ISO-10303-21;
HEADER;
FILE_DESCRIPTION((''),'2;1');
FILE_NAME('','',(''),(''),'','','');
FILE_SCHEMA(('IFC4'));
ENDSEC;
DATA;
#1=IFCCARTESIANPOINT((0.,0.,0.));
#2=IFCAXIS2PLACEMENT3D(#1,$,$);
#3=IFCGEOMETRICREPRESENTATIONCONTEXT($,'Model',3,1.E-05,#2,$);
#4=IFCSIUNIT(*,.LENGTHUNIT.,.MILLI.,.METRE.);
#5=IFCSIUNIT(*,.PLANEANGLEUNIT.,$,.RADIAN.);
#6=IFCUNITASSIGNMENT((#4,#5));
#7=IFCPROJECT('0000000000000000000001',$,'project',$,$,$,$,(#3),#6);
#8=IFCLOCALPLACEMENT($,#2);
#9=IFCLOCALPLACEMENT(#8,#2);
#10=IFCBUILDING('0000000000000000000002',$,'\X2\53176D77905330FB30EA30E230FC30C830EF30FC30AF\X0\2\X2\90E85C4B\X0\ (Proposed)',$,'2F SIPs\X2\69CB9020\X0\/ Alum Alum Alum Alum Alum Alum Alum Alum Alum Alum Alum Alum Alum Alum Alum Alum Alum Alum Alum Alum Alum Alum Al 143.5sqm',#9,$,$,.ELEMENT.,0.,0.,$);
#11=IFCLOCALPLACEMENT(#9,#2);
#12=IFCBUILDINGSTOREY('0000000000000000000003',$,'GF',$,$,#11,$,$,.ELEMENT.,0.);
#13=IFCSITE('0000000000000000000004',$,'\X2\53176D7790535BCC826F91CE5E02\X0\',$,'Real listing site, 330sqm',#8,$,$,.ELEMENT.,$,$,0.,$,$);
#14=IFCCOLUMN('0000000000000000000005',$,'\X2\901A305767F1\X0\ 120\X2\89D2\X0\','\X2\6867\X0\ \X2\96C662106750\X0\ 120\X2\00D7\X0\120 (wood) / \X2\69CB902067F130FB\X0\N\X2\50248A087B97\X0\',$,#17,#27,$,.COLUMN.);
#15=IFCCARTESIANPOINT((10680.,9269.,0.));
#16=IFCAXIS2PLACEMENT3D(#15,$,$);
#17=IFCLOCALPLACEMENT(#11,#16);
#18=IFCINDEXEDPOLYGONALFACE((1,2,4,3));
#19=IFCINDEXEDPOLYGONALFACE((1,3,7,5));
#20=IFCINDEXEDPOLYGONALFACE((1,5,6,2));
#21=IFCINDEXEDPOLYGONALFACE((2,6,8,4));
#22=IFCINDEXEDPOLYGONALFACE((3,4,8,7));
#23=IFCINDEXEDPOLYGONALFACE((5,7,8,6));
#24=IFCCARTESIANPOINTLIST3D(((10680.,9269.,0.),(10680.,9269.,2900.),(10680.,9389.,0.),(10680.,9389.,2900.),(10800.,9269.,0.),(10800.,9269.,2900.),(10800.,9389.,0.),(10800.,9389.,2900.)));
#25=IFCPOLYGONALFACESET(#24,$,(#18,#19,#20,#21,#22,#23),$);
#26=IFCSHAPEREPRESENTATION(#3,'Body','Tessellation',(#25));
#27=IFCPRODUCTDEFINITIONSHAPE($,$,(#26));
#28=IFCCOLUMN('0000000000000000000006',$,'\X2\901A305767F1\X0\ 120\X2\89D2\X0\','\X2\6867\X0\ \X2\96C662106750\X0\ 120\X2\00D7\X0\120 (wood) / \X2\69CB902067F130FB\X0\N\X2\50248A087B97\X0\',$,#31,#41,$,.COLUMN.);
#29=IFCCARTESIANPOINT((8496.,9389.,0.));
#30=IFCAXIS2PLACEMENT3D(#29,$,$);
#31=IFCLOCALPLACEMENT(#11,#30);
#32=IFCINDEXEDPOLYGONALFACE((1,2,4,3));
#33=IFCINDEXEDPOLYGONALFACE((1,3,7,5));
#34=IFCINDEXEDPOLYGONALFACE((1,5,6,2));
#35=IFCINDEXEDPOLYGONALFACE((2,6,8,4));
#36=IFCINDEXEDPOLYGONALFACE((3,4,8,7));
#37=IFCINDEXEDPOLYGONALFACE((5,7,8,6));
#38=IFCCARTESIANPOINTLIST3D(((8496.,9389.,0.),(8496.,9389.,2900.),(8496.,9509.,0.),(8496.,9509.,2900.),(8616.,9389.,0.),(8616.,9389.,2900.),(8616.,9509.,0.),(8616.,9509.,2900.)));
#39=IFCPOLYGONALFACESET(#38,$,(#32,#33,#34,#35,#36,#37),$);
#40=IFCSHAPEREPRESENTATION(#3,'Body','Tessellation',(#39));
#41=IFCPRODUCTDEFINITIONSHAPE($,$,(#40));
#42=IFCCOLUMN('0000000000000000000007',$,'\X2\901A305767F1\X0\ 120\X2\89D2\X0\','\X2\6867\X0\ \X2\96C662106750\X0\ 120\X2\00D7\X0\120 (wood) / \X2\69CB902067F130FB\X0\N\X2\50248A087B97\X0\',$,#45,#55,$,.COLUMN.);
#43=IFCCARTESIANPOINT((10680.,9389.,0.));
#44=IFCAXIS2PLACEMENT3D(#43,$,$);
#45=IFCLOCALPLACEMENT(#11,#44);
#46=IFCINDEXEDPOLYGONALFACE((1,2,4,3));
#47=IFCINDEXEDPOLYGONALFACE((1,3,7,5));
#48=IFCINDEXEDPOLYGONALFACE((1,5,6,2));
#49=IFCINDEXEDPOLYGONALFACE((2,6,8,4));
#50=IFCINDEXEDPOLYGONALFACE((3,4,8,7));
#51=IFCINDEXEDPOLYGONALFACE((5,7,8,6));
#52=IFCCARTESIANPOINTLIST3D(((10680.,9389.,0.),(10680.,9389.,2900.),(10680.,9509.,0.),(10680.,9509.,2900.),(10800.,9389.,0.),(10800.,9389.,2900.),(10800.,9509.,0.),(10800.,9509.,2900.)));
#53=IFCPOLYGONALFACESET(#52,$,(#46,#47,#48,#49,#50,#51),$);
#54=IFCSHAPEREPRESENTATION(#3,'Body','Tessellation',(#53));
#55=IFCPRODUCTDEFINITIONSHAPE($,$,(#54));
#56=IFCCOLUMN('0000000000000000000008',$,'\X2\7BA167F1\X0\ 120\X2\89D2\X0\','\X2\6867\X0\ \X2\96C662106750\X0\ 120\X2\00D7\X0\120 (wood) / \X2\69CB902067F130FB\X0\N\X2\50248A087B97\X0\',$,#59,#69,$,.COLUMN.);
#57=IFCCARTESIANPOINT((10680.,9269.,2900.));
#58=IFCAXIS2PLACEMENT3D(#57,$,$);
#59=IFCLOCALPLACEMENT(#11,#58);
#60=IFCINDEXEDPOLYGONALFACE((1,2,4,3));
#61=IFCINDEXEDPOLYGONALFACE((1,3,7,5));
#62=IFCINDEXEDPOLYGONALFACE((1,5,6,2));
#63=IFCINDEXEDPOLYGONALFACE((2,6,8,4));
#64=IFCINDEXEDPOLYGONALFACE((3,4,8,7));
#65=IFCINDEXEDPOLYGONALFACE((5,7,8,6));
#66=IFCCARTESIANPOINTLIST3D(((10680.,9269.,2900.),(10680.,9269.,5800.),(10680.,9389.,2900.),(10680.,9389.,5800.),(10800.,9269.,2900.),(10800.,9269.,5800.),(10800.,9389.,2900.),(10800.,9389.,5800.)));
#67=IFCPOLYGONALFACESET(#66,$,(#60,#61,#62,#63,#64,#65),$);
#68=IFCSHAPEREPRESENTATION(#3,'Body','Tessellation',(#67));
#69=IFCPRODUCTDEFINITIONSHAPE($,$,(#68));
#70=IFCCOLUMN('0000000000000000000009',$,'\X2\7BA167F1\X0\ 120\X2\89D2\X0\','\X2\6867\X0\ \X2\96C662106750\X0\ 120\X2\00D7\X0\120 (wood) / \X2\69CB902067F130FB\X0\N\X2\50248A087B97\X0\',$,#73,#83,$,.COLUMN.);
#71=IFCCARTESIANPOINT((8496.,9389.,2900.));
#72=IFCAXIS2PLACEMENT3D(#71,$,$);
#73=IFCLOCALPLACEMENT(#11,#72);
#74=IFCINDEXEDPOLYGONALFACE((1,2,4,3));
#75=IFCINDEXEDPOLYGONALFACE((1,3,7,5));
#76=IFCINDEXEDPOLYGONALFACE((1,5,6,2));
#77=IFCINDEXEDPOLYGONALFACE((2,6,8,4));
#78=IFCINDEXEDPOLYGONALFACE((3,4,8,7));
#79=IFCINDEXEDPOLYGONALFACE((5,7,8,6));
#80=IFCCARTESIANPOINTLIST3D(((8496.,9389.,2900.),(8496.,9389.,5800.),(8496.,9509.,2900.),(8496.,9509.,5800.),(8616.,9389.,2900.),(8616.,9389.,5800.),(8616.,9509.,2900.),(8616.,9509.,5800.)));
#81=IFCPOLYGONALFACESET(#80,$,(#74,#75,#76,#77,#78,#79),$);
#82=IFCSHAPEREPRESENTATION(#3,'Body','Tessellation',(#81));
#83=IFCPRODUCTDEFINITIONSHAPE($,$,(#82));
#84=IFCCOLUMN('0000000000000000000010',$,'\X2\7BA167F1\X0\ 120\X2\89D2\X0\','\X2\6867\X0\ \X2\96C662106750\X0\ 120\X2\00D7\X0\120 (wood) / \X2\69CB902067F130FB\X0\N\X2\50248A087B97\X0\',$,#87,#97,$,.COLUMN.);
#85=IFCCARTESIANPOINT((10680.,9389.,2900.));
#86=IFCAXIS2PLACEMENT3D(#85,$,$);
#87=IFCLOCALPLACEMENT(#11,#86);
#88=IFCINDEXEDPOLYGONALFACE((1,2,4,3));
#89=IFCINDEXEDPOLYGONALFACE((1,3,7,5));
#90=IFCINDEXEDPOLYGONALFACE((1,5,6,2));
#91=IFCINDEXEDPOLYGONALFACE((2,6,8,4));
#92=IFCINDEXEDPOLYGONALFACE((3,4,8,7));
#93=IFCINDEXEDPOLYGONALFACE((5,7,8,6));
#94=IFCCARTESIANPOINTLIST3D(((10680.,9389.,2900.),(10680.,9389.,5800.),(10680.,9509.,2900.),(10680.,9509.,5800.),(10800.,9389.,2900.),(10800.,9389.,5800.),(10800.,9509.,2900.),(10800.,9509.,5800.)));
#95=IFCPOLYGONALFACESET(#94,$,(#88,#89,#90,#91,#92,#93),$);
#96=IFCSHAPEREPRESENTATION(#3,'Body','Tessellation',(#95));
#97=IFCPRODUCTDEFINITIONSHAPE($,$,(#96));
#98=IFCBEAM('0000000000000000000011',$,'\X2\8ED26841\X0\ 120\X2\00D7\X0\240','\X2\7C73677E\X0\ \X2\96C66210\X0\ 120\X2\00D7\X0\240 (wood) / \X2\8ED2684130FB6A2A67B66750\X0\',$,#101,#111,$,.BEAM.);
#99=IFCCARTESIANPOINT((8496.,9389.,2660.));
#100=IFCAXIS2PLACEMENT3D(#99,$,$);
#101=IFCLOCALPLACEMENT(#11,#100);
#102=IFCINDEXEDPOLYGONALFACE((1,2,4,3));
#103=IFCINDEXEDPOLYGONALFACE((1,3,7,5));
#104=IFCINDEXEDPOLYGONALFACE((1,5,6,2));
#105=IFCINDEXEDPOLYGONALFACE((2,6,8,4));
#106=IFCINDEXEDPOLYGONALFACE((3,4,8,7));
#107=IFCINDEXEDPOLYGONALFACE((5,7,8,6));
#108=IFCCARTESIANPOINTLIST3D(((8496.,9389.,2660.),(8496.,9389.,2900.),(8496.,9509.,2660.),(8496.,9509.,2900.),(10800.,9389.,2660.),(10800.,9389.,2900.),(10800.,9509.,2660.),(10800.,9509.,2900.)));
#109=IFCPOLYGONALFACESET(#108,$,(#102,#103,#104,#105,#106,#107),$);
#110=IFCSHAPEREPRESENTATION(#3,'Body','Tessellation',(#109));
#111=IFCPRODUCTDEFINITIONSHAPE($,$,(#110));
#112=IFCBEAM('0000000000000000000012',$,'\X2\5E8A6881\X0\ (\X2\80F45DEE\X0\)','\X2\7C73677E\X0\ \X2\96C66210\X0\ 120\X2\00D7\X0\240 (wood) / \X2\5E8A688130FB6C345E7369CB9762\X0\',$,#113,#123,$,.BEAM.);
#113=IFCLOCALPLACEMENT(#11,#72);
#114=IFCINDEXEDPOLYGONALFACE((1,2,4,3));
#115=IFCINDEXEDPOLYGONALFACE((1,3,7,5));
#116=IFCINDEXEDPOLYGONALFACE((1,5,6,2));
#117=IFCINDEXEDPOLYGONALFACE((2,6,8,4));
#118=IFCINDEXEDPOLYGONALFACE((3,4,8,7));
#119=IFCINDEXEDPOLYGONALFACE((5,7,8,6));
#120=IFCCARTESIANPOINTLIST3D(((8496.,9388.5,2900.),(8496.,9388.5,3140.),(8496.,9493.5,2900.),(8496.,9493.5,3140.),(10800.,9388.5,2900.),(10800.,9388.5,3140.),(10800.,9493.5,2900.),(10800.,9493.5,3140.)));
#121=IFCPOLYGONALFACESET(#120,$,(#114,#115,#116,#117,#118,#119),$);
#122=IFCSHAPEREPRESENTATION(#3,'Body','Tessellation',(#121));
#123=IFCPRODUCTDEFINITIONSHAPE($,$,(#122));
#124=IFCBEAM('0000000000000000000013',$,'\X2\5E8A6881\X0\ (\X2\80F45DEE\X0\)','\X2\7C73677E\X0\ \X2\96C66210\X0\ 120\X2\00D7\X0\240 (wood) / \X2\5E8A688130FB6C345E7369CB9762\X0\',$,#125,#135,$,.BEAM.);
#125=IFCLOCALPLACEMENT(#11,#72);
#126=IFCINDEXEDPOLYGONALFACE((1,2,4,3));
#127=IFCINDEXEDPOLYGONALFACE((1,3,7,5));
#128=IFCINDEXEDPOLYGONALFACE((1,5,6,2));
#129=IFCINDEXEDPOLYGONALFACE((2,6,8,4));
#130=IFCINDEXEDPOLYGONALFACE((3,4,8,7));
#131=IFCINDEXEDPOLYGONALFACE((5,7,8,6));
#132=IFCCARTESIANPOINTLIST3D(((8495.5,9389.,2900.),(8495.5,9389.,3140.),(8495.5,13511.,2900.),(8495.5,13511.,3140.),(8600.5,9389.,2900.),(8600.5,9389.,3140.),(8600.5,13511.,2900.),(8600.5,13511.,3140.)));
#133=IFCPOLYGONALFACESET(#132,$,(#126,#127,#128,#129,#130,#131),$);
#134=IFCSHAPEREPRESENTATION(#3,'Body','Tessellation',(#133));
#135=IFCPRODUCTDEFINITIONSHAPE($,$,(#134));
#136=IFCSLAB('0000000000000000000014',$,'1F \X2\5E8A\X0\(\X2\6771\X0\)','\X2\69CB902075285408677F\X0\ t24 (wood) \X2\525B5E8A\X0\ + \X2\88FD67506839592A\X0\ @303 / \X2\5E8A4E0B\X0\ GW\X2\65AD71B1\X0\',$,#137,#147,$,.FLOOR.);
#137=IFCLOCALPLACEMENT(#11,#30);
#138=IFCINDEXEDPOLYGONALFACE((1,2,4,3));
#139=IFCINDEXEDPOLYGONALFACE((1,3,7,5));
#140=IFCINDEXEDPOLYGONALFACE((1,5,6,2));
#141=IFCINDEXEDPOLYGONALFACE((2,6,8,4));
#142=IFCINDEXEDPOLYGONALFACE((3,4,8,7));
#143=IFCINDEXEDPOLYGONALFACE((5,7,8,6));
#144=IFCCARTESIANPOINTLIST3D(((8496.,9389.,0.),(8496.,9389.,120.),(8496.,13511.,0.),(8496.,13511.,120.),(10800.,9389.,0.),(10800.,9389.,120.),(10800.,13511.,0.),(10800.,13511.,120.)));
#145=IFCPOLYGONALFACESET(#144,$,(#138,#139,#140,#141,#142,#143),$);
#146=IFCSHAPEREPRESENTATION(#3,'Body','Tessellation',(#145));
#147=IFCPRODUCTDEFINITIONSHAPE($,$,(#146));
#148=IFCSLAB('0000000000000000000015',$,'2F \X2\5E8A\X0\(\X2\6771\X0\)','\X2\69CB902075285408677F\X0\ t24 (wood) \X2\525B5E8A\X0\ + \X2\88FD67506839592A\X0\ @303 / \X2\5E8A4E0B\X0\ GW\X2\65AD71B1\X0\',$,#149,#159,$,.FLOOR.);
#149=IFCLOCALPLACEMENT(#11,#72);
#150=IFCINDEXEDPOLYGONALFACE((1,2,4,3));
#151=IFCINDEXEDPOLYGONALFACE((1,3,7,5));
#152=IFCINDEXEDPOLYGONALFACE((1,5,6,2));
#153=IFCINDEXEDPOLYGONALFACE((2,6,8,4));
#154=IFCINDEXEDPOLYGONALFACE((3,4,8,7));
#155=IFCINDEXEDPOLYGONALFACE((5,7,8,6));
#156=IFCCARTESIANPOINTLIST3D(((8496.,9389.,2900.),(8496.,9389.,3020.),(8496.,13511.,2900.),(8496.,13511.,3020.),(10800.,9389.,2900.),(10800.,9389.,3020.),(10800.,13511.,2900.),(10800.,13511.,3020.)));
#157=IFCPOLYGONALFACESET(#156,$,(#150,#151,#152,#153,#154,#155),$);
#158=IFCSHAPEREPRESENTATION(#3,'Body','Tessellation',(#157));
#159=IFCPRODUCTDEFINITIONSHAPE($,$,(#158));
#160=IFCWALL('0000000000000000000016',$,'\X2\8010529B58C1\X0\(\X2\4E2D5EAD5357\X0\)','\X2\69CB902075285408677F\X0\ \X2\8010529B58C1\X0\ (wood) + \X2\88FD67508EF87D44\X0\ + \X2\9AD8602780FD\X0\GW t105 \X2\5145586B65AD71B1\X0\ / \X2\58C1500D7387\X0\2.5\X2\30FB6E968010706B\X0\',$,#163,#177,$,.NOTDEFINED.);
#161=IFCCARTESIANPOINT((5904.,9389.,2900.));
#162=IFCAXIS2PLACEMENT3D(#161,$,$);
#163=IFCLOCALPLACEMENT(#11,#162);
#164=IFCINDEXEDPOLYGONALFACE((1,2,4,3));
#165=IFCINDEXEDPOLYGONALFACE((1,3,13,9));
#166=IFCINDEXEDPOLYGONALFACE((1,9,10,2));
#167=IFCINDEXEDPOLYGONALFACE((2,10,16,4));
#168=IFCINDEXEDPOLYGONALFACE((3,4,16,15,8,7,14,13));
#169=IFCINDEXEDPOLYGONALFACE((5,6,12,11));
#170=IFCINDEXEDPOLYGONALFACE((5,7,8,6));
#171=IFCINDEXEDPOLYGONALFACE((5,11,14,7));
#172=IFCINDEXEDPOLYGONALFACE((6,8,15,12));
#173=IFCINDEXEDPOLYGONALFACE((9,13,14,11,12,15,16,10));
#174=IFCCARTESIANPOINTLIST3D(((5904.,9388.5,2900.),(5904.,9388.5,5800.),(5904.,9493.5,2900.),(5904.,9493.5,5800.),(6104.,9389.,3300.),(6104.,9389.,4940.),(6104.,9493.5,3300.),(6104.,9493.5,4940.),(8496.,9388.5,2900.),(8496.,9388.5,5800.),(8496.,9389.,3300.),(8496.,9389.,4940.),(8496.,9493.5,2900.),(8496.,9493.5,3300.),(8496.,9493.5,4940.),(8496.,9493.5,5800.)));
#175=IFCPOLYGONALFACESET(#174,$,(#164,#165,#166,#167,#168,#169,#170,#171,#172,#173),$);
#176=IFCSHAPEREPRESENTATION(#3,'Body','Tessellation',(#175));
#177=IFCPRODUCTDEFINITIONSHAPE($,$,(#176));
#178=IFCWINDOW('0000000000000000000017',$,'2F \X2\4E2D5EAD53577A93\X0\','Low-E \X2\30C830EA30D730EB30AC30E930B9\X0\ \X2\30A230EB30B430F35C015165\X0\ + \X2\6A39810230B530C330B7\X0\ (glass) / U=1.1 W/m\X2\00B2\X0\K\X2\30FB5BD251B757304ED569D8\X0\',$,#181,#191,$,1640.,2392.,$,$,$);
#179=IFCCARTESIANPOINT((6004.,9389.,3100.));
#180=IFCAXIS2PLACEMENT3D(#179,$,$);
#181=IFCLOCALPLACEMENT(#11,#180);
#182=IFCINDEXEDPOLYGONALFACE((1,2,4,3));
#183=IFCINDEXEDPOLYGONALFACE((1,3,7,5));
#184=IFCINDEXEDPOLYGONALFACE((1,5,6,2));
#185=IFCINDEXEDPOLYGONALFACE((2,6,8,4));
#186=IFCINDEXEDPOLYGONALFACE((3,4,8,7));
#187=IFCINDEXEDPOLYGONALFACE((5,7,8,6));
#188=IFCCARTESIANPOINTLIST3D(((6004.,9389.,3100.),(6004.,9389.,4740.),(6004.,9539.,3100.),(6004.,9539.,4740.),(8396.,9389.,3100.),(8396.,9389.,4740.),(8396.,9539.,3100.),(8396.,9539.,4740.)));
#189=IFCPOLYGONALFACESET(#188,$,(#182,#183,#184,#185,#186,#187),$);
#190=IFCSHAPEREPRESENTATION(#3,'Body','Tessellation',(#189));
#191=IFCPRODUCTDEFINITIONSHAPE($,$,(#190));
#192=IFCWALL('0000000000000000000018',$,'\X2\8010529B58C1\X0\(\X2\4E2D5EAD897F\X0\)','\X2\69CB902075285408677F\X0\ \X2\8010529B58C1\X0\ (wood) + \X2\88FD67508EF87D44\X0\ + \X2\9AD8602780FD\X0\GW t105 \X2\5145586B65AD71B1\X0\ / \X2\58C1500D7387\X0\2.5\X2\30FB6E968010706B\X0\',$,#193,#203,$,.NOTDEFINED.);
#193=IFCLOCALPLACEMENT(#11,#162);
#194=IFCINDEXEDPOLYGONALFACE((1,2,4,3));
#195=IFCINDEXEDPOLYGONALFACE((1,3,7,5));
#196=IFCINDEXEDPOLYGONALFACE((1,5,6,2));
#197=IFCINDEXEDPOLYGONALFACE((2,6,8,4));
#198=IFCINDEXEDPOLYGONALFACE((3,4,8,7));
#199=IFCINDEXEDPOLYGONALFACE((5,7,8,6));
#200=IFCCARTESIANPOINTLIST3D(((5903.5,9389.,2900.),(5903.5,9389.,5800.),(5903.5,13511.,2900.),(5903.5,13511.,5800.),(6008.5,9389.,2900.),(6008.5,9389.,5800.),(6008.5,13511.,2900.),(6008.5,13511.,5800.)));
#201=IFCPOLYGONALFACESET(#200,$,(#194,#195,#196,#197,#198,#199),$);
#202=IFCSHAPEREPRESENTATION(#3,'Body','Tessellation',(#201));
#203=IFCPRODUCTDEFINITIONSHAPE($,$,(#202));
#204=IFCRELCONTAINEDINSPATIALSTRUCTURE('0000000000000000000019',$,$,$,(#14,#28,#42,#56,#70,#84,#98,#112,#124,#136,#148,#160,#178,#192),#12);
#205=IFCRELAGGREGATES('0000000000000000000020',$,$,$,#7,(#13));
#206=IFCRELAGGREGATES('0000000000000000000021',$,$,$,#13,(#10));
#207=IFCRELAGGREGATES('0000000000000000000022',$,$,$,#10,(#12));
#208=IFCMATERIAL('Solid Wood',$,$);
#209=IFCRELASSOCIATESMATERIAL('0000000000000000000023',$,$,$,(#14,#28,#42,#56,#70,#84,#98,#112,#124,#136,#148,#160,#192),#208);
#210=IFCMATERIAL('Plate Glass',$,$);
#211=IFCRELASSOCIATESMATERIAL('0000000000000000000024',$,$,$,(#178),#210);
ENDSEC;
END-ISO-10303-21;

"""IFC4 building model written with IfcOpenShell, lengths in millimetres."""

from ifc_helpers import new_model, si_unit, frame, frame_2d, origin, place, context, project, spatial, rectangle, extrude, material, element, fill, save


model = new_model("IFC4")

# Units and contexts
model_context = context("Model", 3, precision=1e-05, world=origin())
ifc_project = project(units=[si_unit("LENGTHUNIT", "METRE", prefix="MILLI"), si_unit("PLANEANGLEUNIT", "RADIAN")], contexts=[model_context])

# Site, building, storey
site_placement = place(None, origin())
site = spatial("IfcSite", under=ifc_project, at=site_placement, Name="北海道富良野市", ObjectType="Real listing site, 330sqm", CompositionType="ELEMENT", RefElevation=0.0)
building_placement = place(site_placement, origin())
building = spatial("IfcBuilding", under=site, at=building_placement, Name="北海道・リモートワーク2部屋 (Proposed)", ObjectType="2F SIPs構造/ Alum Alum Alum Alum Alum Alum Alum Alum Alum Alum Alum Alum Alum Alum Alum Alum Alum Alum Alum Alum Alum Alum Al 143.5sqm", CompositionType="ELEMENT", ElevationOfRefHeight=0.0, ElevationOfTerrain=0.0)
storey_placement = place(building_placement, origin())
storey = spatial("IfcBuildingStorey", under=building, at=storey_placement, Name="GF", CompositionType="ELEMENT", Elevation=0.0)

# Columns
ifc_material_1 = material(Name="Solid Wood")
column_1_placement = place(storey_placement, frame((10680.0, 9269.0, 0.0)))
element("IfcColumn", 1, at=column_1_placement, inside=storey, material=ifc_material_1, Name="通し柱 120角", Description="桧 集成材 120×120 (wood) / 構造柱・N値計算", PredefinedType="COLUMN", context=model_context, shape_type="SweptSolid", body=[
    extrude(rectangle(XDim=120.0, YDim=120.0, at=frame_2d((60.0, 60.0))), frame((10680.0, 9269.0, 0.0)), (0.0, 0.0, 1.0), 2900.0),
])
column_2_placement = place(storey_placement, frame((8496.0, 9389.0, 0.0)))
element("IfcColumn", 2, at=column_2_placement, inside=storey, material=ifc_material_1, Name="通し柱 120角", Description="桧 集成材 120×120 (wood) / 構造柱・N値計算", PredefinedType="COLUMN", context=model_context, shape_type="SweptSolid", body=[
    extrude(rectangle(XDim=120.0, YDim=120.0, at=frame_2d((60.0, 60.0))), frame((8496.0, 9389.0, 0.0)), (0.0, 0.0, 1.0), 2900.0),
])
column_3_placement = place(storey_placement, frame((10680.0, 9389.0, 0.0)))
element("IfcColumn", 3, at=column_3_placement, inside=storey, material=ifc_material_1, Name="通し柱 120角", Description="桧 集成材 120×120 (wood) / 構造柱・N値計算", PredefinedType="COLUMN", context=model_context, shape_type="SweptSolid", body=[
    extrude(rectangle(XDim=120.0, YDim=120.0, at=frame_2d((60.0, 60.0))), frame((10680.0, 9389.0, 0.0)), (0.0, 0.0, 1.0), 2900.0),
])
column_4_placement = place(storey_placement, frame((10680.0, 9269.0, 2900.0)))
element("IfcColumn", 4, at=column_4_placement, inside=storey, material=ifc_material_1, Name="管柱 120角", Description="桧 集成材 120×120 (wood) / 構造柱・N値計算", PredefinedType="COLUMN", context=model_context, shape_type="SweptSolid", body=[
    extrude(rectangle(XDim=120.0, YDim=120.0, at=frame_2d((60.0, 60.0))), frame((10680.0, 9269.0, 2900.0)), (0.0, 0.0, 1.0), 2900.0),
])
column_5_placement = place(storey_placement, frame((8496.0, 9389.0, 2900.0)))
element("IfcColumn", 5, at=column_5_placement, inside=storey, material=ifc_material_1, Name="管柱 120角", Description="桧 集成材 120×120 (wood) / 構造柱・N値計算", PredefinedType="COLUMN", context=model_context, shape_type="SweptSolid", body=[
    extrude(rectangle(XDim=120.0, YDim=120.0, at=frame_2d((60.0, 60.0))), frame((8496.0, 9389.0, 2900.0)), (0.0, 0.0, 1.0), 2900.0),
])
column_6_placement = place(storey_placement, frame((10680.0, 9389.0, 2900.0)))
element("IfcColumn", 6, at=column_6_placement, inside=storey, material=ifc_material_1, Name="管柱 120角", Description="桧 集成材 120×120 (wood) / 構造柱・N値計算", PredefinedType="COLUMN", context=model_context, shape_type="SweptSolid", body=[
    extrude(rectangle(XDim=120.0, YDim=120.0, at=frame_2d((60.0, 60.0))), frame((10680.0, 9389.0, 2900.0)), (0.0, 0.0, 1.0), 2900.0),
])

# Beams
beam_1_placement = place(storey_placement, frame((8496.0, 9389.0, 2660.0)))
element("IfcBeam", 7, at=beam_1_placement, inside=storey, material=ifc_material_1, Name="軒桁 120×240", Description="米松 集成 120×240 (wood) / 軒桁・横架材", PredefinedType="BEAM", context=model_context, shape_type="SweptSolid", body=[
    extrude(rectangle(XDim=2304.0, YDim=120.0, at=frame_2d((1152.0, 60.0))), frame((8496.0, 9389.0, 2660.0)), (0.0, 0.0, 1.0), 240.0),
])
beam_2_placement = place(storey_placement, frame((8496.0, 9389.0, 2900.0)))
element("IfcBeam", 8, at=beam_2_placement, inside=storey, material=ifc_material_1, Name="床梁 (胴差)", Description="米松 集成 120×240 (wood) / 床梁・水平構面", PredefinedType="BEAM", context=model_context, shape_type="SweptSolid", body=[
    extrude(rectangle(XDim=2304.0, YDim=105.0, at=frame_2d((1152.0, 52.0))), frame((8496.0, 9389.0, 2900.0)), (0.0, 0.0, 1.0), 240.0),
])
beam_3_placement = place(storey_placement, frame((8496.0, 9389.0, 2900.0)))
element("IfcBeam", 9, at=beam_3_placement, inside=storey, material=ifc_material_1, Name="床梁 (胴差)", Description="米松 集成 120×240 (wood) / 床梁・水平構面", PredefinedType="BEAM", context=model_context, shape_type="SweptSolid", body=[
    extrude(rectangle(XDim=105.0, YDim=4122.0, at=frame_2d((52.0, 2061.0))), frame((8496.0, 9389.0, 2900.0)), (0.0, 0.0, 1.0), 240.0),
])

# Slabs
slab_1_placement = place(storey_placement, frame((8496.0, 9389.0, 0.0)))
element("IfcSlab", 10, at=slab_1_placement, inside=storey, material=ifc_material_1, Name="1F 床(東)", Description="構造用合板 t24 (wood) 剛床 + 製材根太 @303 / 床下 GW断熱", PredefinedType="FLOOR", context=model_context, shape_type="SweptSolid", body=[
    extrude(rectangle(XDim=2304.0, YDim=4122.0, at=frame_2d((1152.0, 2061.0))), frame((8496.0, 9389.0, 0.0)), (0.0, 0.0, 1.0), 120.0),
])
slab_2_placement = place(storey_placement, frame((8496.0, 9389.0, 2900.0)))
element("IfcSlab", 11, at=slab_2_placement, inside=storey, material=ifc_material_1, Name="2F 床(東)", Description="構造用合板 t24 (wood) 剛床 + 製材根太 @303 / 床下 GW断熱", PredefinedType="FLOOR", context=model_context, shape_type="SweptSolid", body=[
    extrude(rectangle(XDim=2304.0, YDim=4122.0, at=frame_2d((1152.0, 2061.0))), frame((8496.0, 9389.0, 2900.0)), (0.0, 0.0, 1.0), 120.0),
])

# Wall, opening, window
wall_1_placement = place(storey_placement, frame((5904.0, 9389.0, 2900.0)))
wall_1 = element("IfcWall", 12, at=wall_1_placement, inside=storey, material=ifc_material_1, Name="耐力壁(中庭南)", Description="構造用合板 耐力壁 (wood) + 製材軸組 + 高性能GW t105 充填断熱 / 壁倍率2.5・準耐火", PredefinedType="NOTDEFINED", context=model_context, shape_type="SweptSolid", body=[
    extrude(rectangle(XDim=2592.0, YDim=105.0, at=frame_2d((1296.0, 52.0))), frame((5904.0, 9389.0, 2900.0)), (0.0, 0.0, 1.0), 2900.0),
])
opening_placement = place(storey_placement, frame((6004.0, 9389.0, 3100.0)))
opening = element("IfcOpeningElement", 13, at=opening_placement, cuts=wall_1, PredefinedType="NOTDEFINED", context=model_context, shape_type="SweptSolid", body=[
    extrude(rectangle(XDim=2392.0, YDim=150.0, at=frame_2d((1196.0, 75.0))), frame((6004.0, 9389.0, 3100.0)), (0.0, 0.0, 1.0), 1640.0),
])
ifc_material_2 = material(Name="Plate Glass")
window_placement = place(storey_placement, frame((6004.0, 9389.0, 3100.0)))
window = element("IfcWindow", 14, at=window_placement, inside=storey, material=ifc_material_2, Name="2F 中庭南窓", Description="Low-E トリプルガラス アルゴン封入 + 樹脂サッシ (glass) / U=1.1 W/m²K・寒冷地仕様", OverallHeight=1640.0, OverallWidth=2392.0, context=model_context, shape_type="SweptSolid", body=[
    extrude(rectangle(XDim=2392.0, YDim=150.0, at=frame_2d((1196.0, 75.0))), frame((6004.0, 9389.0, 3100.0)), (0.0, 0.0, 1.0), 1640.0),
])
fill(opening, window)

# Wall
wall_2_placement = place(storey_placement, frame((5904.0, 9389.0, 2900.0)))
element("IfcWall", 15, at=wall_2_placement, inside=storey, material=ifc_material_1, Name="耐力壁(中庭西)", Description="構造用合板 耐力壁 (wood) + 製材軸組 + 高性能GW t105 充填断熱 / 壁倍率2.5・準耐火", PredefinedType="NOTDEFINED", context=model_context, shape_type="SweptSolid", body=[
    extrude(rectangle(XDim=105.0, YDim=4122.0, at=frame_2d((52.0, 2061.0))), frame((5904.0, 9389.0, 2900.0)), (0.0, 0.0, 1.0), 2900.0),
])

save(model, "model.ifc")
